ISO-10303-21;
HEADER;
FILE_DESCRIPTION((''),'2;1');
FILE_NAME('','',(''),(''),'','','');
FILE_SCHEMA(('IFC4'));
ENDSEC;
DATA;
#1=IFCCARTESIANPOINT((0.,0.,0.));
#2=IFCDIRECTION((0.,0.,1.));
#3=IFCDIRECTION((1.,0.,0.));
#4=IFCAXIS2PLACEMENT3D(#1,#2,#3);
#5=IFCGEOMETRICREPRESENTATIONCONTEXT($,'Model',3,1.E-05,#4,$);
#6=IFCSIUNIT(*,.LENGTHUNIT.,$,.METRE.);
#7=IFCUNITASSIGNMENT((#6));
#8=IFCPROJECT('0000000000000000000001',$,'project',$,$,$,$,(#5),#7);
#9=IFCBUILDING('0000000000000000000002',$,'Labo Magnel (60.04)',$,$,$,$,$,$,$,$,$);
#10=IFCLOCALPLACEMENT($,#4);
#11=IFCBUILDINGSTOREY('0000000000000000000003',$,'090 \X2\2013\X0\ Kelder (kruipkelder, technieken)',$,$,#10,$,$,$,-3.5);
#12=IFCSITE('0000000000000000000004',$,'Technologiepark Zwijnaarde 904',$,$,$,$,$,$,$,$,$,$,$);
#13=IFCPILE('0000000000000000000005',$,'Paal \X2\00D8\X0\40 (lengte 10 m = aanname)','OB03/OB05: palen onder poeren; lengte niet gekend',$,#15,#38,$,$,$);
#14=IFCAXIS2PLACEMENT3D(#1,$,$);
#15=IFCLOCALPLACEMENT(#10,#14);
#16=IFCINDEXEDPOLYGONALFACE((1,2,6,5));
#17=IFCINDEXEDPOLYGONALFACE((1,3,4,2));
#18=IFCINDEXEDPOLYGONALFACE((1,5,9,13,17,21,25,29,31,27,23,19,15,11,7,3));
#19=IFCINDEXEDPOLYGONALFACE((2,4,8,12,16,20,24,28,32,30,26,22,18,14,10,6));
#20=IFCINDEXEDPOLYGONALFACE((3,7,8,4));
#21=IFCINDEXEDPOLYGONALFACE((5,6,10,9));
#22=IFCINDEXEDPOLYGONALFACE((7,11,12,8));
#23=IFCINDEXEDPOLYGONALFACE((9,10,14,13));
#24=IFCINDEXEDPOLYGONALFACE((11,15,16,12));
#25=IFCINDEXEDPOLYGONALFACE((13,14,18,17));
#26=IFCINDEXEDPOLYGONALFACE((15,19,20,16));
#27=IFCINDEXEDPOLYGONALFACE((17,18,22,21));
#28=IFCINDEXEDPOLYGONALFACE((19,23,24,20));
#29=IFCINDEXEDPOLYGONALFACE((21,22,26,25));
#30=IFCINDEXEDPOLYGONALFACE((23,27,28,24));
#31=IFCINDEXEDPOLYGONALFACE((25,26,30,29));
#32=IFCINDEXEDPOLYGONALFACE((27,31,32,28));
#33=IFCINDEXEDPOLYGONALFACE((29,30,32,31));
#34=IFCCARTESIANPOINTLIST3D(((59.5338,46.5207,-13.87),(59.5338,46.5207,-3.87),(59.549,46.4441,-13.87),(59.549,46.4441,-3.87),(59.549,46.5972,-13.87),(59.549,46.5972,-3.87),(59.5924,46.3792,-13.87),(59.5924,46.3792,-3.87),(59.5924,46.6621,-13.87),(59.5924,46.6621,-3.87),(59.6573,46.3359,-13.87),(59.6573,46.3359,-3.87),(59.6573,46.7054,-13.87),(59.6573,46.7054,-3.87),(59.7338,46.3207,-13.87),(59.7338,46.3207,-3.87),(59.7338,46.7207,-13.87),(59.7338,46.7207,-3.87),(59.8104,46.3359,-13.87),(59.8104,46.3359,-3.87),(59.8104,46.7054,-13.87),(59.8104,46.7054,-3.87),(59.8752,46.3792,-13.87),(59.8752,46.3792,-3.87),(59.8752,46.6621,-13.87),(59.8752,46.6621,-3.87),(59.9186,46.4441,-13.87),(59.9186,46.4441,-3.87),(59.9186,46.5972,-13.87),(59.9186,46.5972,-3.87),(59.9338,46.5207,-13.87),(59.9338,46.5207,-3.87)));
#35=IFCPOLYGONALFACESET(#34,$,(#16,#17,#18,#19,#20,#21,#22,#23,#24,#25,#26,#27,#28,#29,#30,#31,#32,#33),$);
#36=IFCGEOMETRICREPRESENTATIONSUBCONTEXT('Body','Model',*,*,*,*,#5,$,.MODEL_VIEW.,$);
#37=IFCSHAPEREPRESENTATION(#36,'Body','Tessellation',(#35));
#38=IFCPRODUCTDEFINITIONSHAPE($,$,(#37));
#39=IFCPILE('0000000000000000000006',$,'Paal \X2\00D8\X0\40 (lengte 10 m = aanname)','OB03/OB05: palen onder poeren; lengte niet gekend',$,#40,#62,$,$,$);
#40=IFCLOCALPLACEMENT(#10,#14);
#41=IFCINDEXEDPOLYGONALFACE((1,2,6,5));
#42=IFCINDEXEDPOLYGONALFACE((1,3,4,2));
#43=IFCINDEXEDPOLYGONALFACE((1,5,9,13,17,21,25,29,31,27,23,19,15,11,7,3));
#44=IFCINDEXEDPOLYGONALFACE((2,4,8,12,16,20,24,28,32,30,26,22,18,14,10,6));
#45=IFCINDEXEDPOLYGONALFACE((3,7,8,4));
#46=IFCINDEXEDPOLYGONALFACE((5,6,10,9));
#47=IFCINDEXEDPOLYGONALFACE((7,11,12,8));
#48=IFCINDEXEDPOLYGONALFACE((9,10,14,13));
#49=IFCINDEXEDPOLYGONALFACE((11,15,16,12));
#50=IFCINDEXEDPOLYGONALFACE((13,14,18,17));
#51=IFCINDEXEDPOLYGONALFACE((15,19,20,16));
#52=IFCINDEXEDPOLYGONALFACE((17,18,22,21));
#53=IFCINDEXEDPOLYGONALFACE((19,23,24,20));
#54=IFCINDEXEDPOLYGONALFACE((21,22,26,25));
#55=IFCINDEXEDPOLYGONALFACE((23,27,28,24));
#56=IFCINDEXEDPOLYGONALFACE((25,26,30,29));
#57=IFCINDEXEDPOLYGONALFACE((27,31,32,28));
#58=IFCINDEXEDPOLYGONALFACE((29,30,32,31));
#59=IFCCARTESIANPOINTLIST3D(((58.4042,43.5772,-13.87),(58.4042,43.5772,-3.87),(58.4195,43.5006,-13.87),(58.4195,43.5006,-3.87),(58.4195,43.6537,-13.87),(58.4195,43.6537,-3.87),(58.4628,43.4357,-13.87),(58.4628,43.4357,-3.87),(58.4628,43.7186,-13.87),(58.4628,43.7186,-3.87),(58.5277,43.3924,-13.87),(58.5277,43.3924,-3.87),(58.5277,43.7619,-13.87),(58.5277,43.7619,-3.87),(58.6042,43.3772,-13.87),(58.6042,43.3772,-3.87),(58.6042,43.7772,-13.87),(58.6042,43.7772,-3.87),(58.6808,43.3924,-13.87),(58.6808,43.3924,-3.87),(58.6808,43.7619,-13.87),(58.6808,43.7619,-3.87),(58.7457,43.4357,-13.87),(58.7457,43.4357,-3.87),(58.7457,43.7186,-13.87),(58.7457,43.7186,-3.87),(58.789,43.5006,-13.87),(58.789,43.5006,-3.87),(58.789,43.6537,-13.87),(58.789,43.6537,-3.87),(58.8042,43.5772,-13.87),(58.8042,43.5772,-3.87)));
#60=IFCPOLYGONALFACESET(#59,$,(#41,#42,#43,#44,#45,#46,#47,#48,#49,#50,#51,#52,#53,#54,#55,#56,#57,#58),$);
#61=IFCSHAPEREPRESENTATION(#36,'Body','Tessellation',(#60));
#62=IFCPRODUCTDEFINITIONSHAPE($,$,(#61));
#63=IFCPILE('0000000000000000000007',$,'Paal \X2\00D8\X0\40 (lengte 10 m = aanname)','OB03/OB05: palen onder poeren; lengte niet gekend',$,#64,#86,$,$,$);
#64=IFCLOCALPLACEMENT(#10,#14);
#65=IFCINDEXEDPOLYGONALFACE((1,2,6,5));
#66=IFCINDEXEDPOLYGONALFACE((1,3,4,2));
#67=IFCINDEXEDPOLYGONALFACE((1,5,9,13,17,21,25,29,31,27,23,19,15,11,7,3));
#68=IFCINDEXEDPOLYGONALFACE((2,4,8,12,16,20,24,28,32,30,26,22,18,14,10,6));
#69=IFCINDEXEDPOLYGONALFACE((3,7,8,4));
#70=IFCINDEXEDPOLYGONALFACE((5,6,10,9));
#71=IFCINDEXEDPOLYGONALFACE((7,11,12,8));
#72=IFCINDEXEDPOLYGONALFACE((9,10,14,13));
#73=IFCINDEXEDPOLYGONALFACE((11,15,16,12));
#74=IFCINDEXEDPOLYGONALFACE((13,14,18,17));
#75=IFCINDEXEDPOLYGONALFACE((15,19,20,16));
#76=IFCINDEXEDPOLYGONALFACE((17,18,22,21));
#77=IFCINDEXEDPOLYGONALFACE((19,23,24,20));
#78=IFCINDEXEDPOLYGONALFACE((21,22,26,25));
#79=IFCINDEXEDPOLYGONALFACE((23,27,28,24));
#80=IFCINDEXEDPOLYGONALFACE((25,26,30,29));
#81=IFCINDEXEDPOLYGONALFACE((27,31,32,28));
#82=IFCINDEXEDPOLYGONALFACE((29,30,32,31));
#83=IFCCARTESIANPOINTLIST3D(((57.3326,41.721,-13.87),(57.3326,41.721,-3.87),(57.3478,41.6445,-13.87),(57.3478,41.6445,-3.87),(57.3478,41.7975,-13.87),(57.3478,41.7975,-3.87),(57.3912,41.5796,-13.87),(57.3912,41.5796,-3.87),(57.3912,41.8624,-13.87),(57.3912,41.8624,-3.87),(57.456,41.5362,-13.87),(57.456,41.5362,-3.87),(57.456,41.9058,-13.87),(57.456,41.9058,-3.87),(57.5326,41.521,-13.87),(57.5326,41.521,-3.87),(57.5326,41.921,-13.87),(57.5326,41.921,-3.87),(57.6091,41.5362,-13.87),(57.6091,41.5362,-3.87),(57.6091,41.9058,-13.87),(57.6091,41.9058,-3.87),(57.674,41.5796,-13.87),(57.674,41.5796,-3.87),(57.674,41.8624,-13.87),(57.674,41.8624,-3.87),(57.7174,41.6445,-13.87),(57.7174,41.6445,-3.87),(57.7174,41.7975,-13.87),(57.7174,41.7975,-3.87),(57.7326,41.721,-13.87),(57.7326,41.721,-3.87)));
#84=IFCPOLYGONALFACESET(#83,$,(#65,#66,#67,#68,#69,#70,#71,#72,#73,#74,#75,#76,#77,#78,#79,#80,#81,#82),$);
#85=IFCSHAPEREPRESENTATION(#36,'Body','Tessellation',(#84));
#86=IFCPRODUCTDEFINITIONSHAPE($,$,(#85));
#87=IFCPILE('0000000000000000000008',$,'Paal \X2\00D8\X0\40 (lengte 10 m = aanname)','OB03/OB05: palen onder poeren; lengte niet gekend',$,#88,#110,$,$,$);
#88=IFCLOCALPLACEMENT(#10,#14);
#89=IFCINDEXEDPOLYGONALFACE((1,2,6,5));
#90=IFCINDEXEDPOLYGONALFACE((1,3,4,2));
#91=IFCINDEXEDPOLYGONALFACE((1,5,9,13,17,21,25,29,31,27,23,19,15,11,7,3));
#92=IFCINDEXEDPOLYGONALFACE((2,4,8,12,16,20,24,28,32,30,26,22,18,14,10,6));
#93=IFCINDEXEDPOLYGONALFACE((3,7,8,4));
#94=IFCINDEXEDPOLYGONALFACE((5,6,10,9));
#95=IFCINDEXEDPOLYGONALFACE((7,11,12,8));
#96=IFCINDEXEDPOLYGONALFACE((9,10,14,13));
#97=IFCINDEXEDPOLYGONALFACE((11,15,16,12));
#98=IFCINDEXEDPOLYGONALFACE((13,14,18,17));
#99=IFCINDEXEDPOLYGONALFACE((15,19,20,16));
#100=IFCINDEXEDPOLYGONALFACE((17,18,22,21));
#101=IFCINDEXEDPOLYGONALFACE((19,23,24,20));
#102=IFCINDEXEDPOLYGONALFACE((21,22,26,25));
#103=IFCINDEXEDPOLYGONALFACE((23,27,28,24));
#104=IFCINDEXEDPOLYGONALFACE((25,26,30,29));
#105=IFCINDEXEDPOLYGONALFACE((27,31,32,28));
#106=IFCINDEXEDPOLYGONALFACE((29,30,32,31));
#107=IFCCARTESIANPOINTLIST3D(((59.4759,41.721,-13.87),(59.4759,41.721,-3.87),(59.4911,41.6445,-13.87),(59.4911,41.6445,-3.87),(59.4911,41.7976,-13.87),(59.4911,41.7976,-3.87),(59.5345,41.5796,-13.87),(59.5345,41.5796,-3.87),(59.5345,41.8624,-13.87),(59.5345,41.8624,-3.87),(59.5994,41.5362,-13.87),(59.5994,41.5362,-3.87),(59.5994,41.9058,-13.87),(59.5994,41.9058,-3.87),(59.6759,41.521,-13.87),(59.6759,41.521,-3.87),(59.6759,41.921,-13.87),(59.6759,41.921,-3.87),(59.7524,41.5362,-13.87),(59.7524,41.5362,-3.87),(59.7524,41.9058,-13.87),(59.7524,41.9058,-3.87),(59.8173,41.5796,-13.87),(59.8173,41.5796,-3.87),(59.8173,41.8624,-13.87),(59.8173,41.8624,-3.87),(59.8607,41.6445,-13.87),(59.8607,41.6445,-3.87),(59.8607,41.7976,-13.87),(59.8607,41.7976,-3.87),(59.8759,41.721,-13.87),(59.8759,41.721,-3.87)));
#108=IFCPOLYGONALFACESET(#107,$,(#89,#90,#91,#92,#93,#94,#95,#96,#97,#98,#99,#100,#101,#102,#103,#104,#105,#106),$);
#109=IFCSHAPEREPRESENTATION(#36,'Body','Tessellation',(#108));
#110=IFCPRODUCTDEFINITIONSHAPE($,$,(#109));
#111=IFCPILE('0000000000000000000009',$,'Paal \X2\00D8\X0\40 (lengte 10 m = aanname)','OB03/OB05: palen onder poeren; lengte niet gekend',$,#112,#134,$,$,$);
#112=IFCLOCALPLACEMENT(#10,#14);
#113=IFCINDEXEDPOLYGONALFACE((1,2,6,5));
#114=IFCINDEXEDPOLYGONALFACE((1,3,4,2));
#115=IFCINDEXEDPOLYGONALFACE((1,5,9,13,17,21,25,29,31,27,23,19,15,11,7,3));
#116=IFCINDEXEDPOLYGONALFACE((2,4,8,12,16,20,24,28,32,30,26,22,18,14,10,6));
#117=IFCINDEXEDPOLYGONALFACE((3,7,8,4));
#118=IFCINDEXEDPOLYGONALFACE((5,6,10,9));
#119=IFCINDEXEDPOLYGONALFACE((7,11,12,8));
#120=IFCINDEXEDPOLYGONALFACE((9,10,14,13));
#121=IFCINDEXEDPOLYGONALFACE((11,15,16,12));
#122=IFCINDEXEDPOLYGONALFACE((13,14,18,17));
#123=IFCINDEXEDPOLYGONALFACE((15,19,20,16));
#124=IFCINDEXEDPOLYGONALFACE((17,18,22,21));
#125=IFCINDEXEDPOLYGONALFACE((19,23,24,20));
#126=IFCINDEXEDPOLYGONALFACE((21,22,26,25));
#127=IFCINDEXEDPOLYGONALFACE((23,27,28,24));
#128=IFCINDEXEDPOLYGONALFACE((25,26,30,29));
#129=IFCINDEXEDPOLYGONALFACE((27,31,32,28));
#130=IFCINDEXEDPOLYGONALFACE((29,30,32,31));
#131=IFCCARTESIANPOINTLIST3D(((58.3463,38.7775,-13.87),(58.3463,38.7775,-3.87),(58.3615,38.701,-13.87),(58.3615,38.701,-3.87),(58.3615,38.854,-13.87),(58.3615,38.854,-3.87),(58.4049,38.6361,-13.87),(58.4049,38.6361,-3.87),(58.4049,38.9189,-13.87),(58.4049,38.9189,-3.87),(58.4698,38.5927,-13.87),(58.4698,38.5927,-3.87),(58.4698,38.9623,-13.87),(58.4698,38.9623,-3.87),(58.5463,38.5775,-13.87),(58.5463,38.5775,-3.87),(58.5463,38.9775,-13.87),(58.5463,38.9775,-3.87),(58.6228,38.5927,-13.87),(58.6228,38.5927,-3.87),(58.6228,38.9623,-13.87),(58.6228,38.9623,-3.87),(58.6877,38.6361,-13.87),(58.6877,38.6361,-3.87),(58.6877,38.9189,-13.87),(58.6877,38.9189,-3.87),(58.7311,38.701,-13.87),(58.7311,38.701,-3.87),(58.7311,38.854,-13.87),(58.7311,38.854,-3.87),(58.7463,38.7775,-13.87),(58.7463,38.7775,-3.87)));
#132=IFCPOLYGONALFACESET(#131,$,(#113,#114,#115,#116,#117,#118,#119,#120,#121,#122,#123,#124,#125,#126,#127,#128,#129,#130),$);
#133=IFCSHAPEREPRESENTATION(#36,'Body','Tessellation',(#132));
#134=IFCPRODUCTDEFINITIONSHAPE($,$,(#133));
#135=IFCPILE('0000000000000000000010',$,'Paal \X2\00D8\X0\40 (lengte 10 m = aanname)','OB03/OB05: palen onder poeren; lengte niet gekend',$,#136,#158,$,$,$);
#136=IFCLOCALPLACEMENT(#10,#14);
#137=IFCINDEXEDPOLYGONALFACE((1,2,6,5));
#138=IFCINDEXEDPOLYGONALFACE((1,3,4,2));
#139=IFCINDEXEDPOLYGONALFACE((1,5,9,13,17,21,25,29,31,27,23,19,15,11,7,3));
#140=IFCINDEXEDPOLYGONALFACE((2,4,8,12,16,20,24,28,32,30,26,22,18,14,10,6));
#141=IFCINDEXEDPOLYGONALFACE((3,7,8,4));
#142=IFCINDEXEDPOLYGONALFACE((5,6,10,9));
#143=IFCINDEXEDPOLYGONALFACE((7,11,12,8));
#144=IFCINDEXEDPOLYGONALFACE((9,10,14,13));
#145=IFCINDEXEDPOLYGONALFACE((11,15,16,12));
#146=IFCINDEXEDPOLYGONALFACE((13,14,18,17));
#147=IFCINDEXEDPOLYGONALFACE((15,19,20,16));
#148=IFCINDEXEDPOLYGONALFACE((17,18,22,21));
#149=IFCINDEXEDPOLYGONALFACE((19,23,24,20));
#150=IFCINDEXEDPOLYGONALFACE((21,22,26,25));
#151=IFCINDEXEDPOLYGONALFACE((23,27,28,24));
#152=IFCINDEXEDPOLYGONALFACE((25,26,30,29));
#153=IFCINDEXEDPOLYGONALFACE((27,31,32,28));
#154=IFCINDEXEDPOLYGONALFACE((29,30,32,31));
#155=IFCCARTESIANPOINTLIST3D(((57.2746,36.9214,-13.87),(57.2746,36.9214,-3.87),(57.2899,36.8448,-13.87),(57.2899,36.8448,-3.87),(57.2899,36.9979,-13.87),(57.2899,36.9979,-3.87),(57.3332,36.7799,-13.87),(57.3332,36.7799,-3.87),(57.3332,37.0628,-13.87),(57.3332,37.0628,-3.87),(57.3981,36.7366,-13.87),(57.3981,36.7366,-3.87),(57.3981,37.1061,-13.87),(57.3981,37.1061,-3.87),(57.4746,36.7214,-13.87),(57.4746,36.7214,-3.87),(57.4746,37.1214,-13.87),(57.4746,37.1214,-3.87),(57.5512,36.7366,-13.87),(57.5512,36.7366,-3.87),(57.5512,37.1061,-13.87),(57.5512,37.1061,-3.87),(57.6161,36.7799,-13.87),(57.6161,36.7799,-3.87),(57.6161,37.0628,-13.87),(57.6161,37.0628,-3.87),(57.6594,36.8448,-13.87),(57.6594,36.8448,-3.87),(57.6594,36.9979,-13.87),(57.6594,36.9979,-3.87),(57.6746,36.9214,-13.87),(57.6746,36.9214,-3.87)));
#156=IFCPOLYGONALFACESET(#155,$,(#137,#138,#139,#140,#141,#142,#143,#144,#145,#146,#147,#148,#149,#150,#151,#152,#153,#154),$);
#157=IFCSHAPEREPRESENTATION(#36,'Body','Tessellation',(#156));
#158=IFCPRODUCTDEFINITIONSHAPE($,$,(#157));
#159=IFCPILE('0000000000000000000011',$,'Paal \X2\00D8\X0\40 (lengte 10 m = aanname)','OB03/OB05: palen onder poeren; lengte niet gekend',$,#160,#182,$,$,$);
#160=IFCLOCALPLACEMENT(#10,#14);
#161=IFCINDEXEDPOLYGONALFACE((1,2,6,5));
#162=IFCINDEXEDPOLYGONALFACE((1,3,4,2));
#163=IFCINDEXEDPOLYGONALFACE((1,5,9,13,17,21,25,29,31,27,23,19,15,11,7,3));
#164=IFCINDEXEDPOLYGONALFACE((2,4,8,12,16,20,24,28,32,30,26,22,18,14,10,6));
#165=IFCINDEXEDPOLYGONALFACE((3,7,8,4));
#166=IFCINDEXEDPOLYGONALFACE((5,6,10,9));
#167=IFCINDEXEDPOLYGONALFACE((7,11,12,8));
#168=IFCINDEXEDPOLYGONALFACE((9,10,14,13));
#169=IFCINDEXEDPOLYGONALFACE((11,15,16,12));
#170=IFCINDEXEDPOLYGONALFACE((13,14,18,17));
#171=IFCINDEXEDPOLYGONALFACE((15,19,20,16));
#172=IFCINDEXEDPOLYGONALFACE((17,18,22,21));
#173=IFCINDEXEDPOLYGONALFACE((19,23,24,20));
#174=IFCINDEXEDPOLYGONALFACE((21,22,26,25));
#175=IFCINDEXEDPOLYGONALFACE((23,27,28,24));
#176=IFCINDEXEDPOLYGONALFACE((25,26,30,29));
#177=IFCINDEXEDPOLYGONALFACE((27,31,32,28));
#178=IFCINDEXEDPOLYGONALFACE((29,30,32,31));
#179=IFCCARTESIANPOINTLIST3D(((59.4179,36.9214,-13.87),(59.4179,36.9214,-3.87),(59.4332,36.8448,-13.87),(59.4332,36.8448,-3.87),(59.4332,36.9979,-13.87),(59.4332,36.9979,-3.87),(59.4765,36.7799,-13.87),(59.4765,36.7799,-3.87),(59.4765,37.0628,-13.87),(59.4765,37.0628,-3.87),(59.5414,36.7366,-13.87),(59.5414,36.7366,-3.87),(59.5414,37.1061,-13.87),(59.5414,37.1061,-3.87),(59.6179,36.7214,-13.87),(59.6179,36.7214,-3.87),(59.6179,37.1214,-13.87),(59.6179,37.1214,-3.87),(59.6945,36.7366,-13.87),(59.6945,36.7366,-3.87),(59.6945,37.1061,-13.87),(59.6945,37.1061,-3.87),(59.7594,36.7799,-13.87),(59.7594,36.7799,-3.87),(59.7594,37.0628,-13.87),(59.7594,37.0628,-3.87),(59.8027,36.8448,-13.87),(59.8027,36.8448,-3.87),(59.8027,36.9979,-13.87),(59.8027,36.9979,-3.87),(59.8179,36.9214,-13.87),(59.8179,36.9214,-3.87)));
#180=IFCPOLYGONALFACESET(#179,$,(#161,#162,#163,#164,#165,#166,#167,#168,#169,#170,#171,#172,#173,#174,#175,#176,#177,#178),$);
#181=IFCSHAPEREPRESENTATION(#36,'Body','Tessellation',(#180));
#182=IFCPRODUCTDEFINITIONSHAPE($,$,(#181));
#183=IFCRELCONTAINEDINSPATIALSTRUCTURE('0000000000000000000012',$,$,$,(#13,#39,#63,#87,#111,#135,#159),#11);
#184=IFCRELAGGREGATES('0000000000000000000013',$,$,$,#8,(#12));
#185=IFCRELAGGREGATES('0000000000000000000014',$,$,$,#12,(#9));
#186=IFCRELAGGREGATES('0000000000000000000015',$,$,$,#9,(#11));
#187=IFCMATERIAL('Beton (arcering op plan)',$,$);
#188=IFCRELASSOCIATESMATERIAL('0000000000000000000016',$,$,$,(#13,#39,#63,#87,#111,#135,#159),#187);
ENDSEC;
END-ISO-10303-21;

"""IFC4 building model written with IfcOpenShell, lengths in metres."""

from ifc_helpers import new_model, si_unit, frame, origin, origin_with_axes, place, context, subcontext, project, spatial, polyline, outline, extrude, material, element, save


model = new_model("IFC4")

# Units and contexts
model_context = context("Model", 3, precision=1e-05, world=origin_with_axes())
body_context = subcontext(model_context, "Body", "Model", "MODEL_VIEW")
ifc_project = project(units=[si_unit("LENGTHUNIT", "METRE")], contexts=[model_context])

# Site, building, storey
site = spatial("IfcSite", under=ifc_project, Name="Technologiepark Zwijnaarde 904")
building = spatial("IfcBuilding", under=site, Name="Labo Magnel (60.04)")
storey_placement = place(None, origin_with_axes())
storey = spatial("IfcBuildingStorey", under=building, at=storey_placement, Name="090 – Kelder (kruipkelder, technieken)", Elevation=-3.5)

# Piles
ifc_material = material(Name="Beton (arcering op plan)")
pile_1_placement = place(storey_placement, frame((0.0, 0.0, -13.87), z_axis=(0.0, 0.0, 1.0), x_axis=(1.0, 0.0, 0.0)))
element("IfcPile", 1, at=pile_1_placement, inside=storey, material=ifc_material, Name="Paal Ø40 (lengte 10 m = aanname)", Description="OB03/OB05: palen onder poeren; lengte niet gekend", context=body_context, shape_type="SweptSolid", body=[
    extrude(outline(polyline([(59.9338, 46.5207), (59.9186, 46.4441), (59.8752, 46.3792), (59.8104, 46.3359), (59.7338, 46.3207), (59.6573, 46.3359), (59.5924, 46.3792), (59.549, 46.4441), (59.5338, 46.5207), (59.549, 46.5972), (59.5924, 46.6621), (59.6573, 46.7054), (59.7338, 46.7207), (59.8104, 46.7054), (59.8752, 46.6621), (59.9186, 46.5972), (59.9338, 46.5207)])), origin(), (0.0, 0.0, 1.0), 10.0),
])
pile_2_placement = place(storey_placement, frame((0.0, 0.0, -13.87), z_axis=(0.0, 0.0, 1.0), x_axis=(1.0, 0.0, 0.0)))
element("IfcPile", 2, at=pile_2_placement, inside=storey, material=ifc_material, Name="Paal Ø40 (lengte 10 m = aanname)", Description="OB03/OB05: palen onder poeren; lengte niet gekend", context=body_context, shape_type="SweptSolid", body=[
    extrude(outline(polyline([(58.8042, 43.5772), (58.789, 43.5006), (58.7457, 43.4357), (58.6808, 43.3924), (58.6042, 43.3772), (58.5277, 43.3924), (58.4628, 43.4357), (58.4195, 43.5006), (58.4042, 43.5772), (58.4195, 43.6537), (58.4628, 43.7186), (58.5277, 43.7619), (58.6042, 43.7772), (58.6808, 43.7619), (58.7457, 43.7186), (58.789, 43.6537), (58.8042, 43.5772)])), origin(), (0.0, 0.0, 1.0), 10.0),
])
pile_3_placement = place(storey_placement, frame((0.0, 0.0, -13.87), z_axis=(0.0, 0.0, 1.0), x_axis=(1.0, 0.0, 0.0)))
element("IfcPile", 3, at=pile_3_placement, inside=storey, material=ifc_material, Name="Paal Ø40 (lengte 10 m = aanname)", Description="OB03/OB05: palen onder poeren; lengte niet gekend", context=body_context, shape_type="SweptSolid", body=[
    extrude(outline(polyline([(57.7326, 41.721), (57.7174, 41.6445), (57.674, 41.5796), (57.6091, 41.5362), (57.5326, 41.521), (57.456, 41.5362), (57.3912, 41.5796), (57.3478, 41.6445), (57.3326, 41.721), (57.3478, 41.7975), (57.3912, 41.8624), (57.456, 41.9058), (57.5326, 41.921), (57.6091, 41.9058), (57.674, 41.8624), (57.7174, 41.7975), (57.7326, 41.721)])), origin(), (0.0, 0.0, 1.0), 10.0),
])
pile_4_placement = place(storey_placement, frame((0.0, 0.0, -13.87), z_axis=(0.0, 0.0, 1.0), x_axis=(1.0, 0.0, 0.0)))
element("IfcPile", 4, at=pile_4_placement, inside=storey, material=ifc_material, Name="Paal Ø40 (lengte 10 m = aanname)", Description="OB03/OB05: palen onder poeren; lengte niet gekend", context=body_context, shape_type="SweptSolid", body=[
    extrude(outline(polyline([(59.8759, 41.721), (59.8607, 41.6445), (59.8173, 41.5796), (59.7524, 41.5362), (59.6759, 41.521), (59.5994, 41.5362), (59.5345, 41.5796), (59.4911, 41.6445), (59.4759, 41.721), (59.4911, 41.7976), (59.5345, 41.8624), (59.5994, 41.9058), (59.6759, 41.921), (59.7524, 41.9058), (59.8173, 41.8624), (59.8607, 41.7976), (59.8759, 41.721)])), origin(), (0.0, 0.0, 1.0), 10.0),
])
pile_5_placement = place(storey_placement, frame((0.0, 0.0, -13.87), z_axis=(0.0, 0.0, 1.0), x_axis=(1.0, 0.0, 0.0)))
element("IfcPile", 5, at=pile_5_placement, inside=storey, material=ifc_material, Name="Paal Ø40 (lengte 10 m = aanname)", Description="OB03/OB05: palen onder poeren; lengte niet gekend", context=body_context, shape_type="SweptSolid", body=[
    extrude(outline(polyline([(58.7463, 38.7775), (58.7311, 38.701), (58.6877, 38.6361), (58.6228, 38.5927), (58.5463, 38.5775), (58.4698, 38.5927), (58.4049, 38.6361), (58.3615, 38.701), (58.3463, 38.7775), (58.3615, 38.854), (58.4049, 38.9189), (58.4698, 38.9623), (58.5463, 38.9775), (58.6228, 38.9623), (58.6877, 38.9189), (58.7311, 38.854), (58.7463, 38.7775)])), origin(), (0.0, 0.0, 1.0), 10.0),
])
pile_6_placement = place(storey_placement, frame((0.0, 0.0, -13.87), z_axis=(0.0, 0.0, 1.0), x_axis=(1.0, 0.0, 0.0)))
element("IfcPile", 6, at=pile_6_placement, inside=storey, material=ifc_material, Name="Paal Ø40 (lengte 10 m = aanname)", Description="OB03/OB05: palen onder poeren; lengte niet gekend", context=body_context, shape_type="SweptSolid", body=[
    extrude(outline(polyline([(57.6746, 36.9214), (57.6594, 36.8448), (57.6161, 36.7799), (57.5512, 36.7366), (57.4746, 36.7214), (57.3981, 36.7366), (57.3332, 36.7799), (57.2899, 36.8448), (57.2746, 36.9214), (57.2899, 36.9979), (57.3332, 37.0628), (57.3981, 37.1061), (57.4746, 37.1214), (57.5512, 37.1061), (57.6161, 37.0628), (57.6594, 36.9979), (57.6746, 36.9214)])), origin(), (0.0, 0.0, 1.0), 10.0),
])
pile_7_placement = place(storey_placement, frame((0.0, 0.0, -13.87), z_axis=(0.0, 0.0, 1.0), x_axis=(1.0, 0.0, 0.0)))
element("IfcPile", 7, at=pile_7_placement, inside=storey, material=ifc_material, Name="Paal Ø40 (lengte 10 m = aanname)", Description="OB03/OB05: palen onder poeren; lengte niet gekend", context=body_context, shape_type="SweptSolid", body=[
    extrude(outline(polyline([(59.8179, 36.9214), (59.8027, 36.8448), (59.7594, 36.7799), (59.6945, 36.7366), (59.6179, 36.7214), (59.5414, 36.7366), (59.4765, 36.7799), (59.4332, 36.8448), (59.4179, 36.9214), (59.4332, 36.9979), (59.4765, 37.0628), (59.5414, 37.1061), (59.6179, 37.1214), (59.6945, 37.1061), (59.7594, 37.0628), (59.8027, 36.9979), (59.8179, 36.9214)])), origin(), (0.0, 0.0, 1.0), 10.0),
])

save(model, "model.ifc")
